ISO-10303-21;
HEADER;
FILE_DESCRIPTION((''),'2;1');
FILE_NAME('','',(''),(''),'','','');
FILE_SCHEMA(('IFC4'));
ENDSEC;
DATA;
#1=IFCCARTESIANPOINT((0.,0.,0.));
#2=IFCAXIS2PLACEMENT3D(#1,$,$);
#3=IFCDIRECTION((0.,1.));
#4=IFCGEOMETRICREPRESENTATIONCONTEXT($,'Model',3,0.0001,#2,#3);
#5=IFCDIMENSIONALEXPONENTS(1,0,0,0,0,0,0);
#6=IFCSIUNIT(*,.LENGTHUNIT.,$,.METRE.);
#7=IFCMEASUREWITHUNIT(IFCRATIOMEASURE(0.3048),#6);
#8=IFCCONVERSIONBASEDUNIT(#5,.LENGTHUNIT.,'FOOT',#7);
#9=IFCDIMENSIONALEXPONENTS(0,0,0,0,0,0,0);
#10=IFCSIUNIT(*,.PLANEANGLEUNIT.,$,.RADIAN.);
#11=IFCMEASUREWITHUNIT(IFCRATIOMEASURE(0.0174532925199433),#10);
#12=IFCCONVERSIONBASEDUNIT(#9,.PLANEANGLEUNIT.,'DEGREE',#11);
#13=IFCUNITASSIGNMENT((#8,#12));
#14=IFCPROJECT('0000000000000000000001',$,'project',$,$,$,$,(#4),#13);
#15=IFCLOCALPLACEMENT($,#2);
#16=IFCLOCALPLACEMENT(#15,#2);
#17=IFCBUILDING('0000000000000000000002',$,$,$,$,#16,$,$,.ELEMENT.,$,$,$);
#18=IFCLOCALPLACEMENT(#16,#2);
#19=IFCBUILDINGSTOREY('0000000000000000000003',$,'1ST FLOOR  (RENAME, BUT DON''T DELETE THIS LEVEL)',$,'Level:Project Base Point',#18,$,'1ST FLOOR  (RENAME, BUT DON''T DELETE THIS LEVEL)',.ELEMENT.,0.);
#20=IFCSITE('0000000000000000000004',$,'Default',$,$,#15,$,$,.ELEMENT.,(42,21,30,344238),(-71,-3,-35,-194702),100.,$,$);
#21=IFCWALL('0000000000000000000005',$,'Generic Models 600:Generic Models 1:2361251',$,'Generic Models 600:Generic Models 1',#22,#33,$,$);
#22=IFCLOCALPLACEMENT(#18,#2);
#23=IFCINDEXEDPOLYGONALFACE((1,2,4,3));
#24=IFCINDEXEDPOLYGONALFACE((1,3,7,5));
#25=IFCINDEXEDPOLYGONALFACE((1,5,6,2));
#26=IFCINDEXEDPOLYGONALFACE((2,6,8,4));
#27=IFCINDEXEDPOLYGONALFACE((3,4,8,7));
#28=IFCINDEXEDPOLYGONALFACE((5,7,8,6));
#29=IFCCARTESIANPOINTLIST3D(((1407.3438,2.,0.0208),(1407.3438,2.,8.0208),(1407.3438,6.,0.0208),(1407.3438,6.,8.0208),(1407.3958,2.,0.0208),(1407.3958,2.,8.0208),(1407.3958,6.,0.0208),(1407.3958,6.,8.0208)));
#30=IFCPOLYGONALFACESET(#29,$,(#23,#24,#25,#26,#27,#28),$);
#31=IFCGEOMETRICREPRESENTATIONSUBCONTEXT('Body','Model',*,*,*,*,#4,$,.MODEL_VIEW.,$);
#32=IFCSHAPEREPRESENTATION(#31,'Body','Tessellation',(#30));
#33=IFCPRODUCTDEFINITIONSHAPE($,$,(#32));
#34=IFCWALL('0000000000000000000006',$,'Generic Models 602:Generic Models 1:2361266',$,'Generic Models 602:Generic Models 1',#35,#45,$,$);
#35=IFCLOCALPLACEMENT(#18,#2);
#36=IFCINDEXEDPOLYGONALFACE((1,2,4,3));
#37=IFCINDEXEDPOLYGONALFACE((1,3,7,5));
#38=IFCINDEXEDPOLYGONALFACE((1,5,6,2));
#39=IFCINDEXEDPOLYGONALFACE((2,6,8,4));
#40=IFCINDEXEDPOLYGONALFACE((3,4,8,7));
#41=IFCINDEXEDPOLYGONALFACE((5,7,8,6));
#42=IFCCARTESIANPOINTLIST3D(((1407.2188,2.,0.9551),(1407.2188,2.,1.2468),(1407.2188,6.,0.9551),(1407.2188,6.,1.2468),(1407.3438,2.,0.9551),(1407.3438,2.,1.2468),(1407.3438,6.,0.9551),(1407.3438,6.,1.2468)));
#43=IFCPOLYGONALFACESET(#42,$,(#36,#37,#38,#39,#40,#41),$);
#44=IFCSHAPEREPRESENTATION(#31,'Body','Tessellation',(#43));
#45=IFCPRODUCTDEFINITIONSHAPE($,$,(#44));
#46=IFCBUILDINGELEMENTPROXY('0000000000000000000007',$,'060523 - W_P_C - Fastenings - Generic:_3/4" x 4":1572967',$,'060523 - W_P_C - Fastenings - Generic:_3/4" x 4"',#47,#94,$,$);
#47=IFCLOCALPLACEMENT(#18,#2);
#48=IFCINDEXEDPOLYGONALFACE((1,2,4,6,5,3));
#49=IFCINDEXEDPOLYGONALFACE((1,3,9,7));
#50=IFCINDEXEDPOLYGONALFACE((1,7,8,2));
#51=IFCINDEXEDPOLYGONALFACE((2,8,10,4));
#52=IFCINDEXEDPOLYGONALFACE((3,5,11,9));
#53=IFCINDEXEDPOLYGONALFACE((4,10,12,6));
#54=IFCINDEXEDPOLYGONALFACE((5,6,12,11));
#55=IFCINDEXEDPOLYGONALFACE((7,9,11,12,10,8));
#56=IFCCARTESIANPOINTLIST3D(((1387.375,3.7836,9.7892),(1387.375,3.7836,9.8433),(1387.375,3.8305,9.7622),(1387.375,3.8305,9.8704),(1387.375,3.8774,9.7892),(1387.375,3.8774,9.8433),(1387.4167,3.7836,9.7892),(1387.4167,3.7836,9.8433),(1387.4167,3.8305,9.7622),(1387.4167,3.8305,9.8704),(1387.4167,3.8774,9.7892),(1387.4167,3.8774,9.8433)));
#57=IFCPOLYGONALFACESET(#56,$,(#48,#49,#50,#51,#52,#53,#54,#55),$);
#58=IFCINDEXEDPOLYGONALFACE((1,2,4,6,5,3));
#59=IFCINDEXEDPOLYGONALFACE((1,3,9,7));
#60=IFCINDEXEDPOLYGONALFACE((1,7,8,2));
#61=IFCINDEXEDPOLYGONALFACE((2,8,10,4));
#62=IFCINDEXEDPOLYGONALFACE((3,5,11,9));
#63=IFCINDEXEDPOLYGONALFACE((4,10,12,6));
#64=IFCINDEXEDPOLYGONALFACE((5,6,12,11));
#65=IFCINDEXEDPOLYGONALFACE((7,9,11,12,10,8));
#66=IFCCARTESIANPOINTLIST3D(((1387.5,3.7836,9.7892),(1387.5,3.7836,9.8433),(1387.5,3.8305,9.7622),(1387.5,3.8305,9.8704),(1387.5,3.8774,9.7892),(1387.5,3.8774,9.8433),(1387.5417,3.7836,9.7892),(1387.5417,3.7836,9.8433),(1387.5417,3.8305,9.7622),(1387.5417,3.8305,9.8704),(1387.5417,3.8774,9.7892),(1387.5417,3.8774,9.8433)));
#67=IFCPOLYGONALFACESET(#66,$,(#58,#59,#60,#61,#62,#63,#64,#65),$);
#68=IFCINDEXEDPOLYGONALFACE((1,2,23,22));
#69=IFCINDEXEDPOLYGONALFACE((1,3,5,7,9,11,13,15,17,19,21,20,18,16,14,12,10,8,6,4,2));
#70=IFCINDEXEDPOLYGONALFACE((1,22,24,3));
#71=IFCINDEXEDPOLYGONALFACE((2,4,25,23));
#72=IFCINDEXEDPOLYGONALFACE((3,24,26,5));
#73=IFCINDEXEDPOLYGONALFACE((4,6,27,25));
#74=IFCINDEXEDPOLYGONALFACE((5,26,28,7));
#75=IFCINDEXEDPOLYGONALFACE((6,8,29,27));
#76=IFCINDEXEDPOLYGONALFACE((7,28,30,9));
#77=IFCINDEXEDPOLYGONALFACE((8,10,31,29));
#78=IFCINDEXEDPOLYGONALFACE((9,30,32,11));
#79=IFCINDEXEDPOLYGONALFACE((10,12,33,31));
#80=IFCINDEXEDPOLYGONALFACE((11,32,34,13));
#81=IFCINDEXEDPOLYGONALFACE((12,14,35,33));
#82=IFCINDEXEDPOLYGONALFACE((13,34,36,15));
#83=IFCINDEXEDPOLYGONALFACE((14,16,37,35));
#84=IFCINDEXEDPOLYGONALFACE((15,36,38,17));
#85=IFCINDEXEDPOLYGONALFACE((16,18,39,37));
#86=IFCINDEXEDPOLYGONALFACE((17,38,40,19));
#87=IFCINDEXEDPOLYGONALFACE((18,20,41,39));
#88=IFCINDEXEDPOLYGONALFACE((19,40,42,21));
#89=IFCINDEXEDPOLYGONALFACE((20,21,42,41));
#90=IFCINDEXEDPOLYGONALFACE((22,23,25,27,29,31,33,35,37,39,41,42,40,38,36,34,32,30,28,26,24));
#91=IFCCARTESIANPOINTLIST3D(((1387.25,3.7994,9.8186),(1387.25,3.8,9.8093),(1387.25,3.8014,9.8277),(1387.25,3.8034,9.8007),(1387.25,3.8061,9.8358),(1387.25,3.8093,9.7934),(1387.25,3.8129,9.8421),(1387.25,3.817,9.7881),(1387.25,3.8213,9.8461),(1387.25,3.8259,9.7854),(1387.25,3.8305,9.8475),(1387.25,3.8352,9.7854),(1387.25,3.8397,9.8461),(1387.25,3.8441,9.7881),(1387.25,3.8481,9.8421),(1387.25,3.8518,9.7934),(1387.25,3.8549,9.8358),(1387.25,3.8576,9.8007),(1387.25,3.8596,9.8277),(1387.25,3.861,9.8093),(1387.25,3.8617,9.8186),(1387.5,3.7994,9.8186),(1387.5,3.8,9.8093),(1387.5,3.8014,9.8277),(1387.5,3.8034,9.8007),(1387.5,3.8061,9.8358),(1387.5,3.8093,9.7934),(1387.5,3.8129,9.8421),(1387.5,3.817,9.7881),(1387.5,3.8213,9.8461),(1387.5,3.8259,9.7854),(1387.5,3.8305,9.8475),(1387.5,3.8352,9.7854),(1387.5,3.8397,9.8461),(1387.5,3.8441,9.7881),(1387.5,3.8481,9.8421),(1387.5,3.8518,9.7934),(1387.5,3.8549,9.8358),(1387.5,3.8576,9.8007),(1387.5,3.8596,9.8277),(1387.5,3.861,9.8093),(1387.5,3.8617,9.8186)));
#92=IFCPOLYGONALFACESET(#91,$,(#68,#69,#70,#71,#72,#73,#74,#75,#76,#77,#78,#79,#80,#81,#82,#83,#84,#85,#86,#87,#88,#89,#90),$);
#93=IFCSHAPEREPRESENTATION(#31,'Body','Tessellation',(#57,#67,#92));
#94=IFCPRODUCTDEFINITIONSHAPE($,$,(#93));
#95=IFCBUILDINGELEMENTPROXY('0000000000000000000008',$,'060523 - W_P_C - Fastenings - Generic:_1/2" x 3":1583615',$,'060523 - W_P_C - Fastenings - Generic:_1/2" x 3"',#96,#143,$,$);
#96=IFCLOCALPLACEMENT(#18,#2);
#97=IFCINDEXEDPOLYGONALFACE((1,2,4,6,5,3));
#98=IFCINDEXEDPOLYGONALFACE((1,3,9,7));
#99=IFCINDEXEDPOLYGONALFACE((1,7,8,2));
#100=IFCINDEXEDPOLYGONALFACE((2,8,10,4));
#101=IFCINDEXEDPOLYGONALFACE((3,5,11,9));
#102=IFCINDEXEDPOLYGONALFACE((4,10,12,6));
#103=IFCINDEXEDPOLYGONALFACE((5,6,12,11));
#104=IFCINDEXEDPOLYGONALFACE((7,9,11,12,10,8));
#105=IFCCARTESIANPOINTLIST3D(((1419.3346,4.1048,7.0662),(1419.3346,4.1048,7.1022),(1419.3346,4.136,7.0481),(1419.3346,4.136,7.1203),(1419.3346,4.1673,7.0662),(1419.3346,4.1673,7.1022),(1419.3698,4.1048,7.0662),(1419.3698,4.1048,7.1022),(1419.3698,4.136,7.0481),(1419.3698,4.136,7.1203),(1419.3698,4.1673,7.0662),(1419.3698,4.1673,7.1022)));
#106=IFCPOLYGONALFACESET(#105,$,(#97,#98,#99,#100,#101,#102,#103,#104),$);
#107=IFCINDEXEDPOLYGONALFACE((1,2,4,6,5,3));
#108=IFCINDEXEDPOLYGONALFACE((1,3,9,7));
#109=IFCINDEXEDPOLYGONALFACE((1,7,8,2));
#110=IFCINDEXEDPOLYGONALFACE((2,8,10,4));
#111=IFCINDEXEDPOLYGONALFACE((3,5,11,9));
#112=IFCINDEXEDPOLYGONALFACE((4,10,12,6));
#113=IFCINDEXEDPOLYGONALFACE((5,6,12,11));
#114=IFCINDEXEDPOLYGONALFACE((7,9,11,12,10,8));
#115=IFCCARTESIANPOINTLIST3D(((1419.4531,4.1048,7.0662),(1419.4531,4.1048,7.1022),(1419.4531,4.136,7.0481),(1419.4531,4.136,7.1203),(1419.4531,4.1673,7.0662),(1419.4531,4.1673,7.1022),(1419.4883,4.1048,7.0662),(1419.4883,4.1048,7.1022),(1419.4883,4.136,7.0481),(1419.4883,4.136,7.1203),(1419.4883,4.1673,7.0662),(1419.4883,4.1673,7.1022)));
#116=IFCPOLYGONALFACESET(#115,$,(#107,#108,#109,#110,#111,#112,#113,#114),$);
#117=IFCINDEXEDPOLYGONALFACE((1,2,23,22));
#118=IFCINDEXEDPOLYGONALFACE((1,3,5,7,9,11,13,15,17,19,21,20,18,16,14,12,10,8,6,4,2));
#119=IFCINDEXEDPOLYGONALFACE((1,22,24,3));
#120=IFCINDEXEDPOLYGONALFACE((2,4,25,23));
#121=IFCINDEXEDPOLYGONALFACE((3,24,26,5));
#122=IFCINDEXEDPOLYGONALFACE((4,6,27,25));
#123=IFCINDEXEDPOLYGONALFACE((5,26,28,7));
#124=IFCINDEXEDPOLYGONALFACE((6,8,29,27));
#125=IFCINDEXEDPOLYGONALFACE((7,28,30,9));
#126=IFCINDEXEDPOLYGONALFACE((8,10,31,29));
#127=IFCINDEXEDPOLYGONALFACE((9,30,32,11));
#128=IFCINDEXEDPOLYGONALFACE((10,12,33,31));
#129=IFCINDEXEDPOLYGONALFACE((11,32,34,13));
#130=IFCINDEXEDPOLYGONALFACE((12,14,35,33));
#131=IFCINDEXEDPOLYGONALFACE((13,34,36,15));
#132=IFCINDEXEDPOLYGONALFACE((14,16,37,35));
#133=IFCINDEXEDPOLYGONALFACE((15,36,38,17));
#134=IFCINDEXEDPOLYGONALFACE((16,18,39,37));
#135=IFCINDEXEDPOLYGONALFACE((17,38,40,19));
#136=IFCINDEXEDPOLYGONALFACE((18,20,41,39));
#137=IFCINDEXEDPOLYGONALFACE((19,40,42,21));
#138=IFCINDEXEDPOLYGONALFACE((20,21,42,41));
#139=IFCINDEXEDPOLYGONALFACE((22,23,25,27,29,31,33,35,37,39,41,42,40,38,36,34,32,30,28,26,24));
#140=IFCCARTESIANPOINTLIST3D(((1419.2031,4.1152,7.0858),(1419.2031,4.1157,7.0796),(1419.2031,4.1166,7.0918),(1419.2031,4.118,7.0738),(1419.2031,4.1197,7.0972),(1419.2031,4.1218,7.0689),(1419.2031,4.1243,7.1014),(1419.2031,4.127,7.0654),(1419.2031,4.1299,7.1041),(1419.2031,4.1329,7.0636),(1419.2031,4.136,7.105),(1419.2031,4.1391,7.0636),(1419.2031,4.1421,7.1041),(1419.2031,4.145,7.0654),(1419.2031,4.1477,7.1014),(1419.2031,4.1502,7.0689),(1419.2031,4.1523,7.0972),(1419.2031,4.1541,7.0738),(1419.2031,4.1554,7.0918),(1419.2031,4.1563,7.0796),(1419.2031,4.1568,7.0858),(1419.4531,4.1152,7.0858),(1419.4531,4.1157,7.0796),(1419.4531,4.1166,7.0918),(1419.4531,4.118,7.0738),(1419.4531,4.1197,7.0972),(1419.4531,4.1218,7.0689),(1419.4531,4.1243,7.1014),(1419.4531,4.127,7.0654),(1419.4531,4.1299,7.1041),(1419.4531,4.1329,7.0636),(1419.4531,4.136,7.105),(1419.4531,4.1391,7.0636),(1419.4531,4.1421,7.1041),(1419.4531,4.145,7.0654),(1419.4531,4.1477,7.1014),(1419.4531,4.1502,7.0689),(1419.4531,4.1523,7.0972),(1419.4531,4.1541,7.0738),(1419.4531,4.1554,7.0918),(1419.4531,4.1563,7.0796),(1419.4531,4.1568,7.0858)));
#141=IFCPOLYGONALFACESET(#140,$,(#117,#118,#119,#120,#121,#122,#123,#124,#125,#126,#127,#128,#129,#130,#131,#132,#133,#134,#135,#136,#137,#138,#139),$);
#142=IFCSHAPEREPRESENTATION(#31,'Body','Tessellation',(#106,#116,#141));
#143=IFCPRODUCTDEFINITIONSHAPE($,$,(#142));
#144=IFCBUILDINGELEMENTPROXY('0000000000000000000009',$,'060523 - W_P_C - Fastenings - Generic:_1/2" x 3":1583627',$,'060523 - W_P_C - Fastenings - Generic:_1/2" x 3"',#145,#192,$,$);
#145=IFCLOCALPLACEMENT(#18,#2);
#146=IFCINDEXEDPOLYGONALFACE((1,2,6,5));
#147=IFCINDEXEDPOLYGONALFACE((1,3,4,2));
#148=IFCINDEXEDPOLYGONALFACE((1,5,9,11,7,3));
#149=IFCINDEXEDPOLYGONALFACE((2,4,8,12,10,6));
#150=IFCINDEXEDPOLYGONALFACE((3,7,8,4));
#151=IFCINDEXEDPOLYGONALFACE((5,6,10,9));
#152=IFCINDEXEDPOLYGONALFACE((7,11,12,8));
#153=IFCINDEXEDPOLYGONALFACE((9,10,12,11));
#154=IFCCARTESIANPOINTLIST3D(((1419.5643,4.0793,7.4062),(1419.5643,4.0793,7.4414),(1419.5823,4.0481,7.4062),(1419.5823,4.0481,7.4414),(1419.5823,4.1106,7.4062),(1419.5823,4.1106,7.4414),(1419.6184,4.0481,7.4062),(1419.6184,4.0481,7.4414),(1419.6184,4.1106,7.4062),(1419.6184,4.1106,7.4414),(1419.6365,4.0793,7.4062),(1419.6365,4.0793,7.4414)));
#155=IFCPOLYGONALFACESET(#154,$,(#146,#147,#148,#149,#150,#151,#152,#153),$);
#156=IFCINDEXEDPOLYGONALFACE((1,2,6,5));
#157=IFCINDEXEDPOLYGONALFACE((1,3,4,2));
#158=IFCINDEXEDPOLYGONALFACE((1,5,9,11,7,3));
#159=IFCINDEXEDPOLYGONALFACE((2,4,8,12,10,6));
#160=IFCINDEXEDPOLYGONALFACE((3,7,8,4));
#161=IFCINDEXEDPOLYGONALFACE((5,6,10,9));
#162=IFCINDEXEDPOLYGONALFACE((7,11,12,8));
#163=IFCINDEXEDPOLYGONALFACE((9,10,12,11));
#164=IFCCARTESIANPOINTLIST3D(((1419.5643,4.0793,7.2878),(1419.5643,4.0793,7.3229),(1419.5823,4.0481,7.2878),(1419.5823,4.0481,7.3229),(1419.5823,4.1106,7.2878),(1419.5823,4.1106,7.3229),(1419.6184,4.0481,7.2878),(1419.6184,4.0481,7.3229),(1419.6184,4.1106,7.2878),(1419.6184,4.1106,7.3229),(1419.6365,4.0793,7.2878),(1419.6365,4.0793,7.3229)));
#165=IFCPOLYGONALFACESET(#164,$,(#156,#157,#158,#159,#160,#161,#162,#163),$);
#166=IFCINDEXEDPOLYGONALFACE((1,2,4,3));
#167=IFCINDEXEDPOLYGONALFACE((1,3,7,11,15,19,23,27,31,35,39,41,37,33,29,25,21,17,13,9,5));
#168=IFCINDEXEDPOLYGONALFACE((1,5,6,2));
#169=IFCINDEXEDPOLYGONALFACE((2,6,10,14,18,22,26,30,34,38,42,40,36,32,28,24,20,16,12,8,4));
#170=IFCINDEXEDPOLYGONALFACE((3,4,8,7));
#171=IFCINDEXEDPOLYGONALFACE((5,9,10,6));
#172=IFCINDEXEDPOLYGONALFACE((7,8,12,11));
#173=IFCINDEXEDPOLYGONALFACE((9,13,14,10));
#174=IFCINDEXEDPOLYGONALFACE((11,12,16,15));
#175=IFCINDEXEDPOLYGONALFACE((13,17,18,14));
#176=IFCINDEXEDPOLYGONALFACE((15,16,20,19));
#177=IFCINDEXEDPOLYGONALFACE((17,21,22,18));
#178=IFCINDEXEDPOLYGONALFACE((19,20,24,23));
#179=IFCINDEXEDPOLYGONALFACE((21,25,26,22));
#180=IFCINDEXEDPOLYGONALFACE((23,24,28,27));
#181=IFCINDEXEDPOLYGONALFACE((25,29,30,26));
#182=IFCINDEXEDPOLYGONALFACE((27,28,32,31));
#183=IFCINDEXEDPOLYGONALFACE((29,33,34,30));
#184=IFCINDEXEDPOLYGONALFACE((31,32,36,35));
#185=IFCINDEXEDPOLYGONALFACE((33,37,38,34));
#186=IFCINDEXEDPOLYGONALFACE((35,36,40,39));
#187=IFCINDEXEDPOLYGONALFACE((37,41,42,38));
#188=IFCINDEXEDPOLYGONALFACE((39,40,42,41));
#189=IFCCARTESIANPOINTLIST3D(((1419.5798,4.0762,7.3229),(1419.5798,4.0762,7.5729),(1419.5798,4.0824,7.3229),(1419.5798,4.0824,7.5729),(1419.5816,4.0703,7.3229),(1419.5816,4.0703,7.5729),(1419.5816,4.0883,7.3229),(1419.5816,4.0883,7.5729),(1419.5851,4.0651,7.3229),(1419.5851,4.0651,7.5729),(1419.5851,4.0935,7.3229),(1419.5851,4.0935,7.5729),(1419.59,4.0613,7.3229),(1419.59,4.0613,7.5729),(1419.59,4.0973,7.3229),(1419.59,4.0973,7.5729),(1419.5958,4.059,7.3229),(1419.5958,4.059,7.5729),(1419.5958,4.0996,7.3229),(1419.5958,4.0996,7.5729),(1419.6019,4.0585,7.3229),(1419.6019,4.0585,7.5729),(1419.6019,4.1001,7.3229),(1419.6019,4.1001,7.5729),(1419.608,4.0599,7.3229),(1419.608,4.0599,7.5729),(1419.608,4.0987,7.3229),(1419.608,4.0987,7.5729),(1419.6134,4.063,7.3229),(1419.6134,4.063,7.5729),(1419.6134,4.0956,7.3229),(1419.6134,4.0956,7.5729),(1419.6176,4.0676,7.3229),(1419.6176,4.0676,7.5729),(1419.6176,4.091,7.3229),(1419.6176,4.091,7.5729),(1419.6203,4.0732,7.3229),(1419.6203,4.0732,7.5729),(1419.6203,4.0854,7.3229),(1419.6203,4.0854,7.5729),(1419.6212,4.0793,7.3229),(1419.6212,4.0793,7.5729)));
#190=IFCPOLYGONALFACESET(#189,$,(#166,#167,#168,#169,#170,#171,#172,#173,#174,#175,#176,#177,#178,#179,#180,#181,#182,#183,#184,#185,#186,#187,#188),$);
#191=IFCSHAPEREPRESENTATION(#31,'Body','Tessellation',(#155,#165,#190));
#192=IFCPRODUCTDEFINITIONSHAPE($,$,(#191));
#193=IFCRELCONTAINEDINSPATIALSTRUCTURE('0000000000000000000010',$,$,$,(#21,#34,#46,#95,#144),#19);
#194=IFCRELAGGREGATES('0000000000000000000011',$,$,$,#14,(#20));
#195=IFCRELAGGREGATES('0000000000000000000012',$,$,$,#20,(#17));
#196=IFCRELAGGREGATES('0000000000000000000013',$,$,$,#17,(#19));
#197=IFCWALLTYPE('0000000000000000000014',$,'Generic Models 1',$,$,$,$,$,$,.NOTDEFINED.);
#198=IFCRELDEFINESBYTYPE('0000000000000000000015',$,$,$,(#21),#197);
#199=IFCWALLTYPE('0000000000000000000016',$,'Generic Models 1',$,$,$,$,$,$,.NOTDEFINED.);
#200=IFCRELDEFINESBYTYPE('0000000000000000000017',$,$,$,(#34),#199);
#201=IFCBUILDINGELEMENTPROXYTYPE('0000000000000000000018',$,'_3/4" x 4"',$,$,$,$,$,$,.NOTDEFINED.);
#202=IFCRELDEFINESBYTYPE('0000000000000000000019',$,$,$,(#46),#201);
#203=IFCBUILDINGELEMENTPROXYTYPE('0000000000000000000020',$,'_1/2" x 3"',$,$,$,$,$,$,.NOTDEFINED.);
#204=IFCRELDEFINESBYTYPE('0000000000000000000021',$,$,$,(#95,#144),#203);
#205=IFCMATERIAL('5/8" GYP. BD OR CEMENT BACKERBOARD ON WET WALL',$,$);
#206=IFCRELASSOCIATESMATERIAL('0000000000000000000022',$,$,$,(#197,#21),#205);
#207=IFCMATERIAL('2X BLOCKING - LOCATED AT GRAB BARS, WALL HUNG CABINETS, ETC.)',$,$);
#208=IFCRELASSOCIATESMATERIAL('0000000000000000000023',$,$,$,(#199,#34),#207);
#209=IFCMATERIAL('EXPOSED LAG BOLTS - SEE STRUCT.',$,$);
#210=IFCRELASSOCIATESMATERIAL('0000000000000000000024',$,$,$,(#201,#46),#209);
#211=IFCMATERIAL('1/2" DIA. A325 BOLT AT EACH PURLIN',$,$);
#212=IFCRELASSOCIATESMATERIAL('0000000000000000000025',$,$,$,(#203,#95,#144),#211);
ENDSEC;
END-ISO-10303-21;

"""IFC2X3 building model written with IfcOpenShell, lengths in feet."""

from ifc_helpers import new_model, entity, si_unit, converted_unit, direction, frame, frame_2d, origin, place, context, subcontext, project, spatial, polyline, rectangle, circle, outline, extrude, source, transform, mapped, material, type_object, type_shapes, element, save


model = new_model("IFC2X3")

# Units and contexts
model_context = context("Model", 3, precision=0.0001, world=origin(), true_north=direction((0.0, 1.0)))
body_context = subcontext(model_context, "Body", "Model", "MODEL_VIEW")
ifc_project = project(units=[converted_unit("LENGTHUNIT", "FOOT", entity("IfcRatioMeasure", 0.3048), si_unit("LENGTHUNIT", "METRE"), dimensions=[1, 0, 0, 0, 0, 0, 0]), converted_unit("PLANEANGLEUNIT", "DEGREE", entity("IfcRatioMeasure", 0.0174532925199433), si_unit("PLANEANGLEUNIT", "RADIAN"), dimensions=[0, 0, 0, 0, 0, 0, 0])], contexts=[model_context])

# Site, building, storey
site_placement = place(None, origin())
site = spatial("IfcSite", under=ifc_project, at=site_placement, Name="Default", CompositionType="ELEMENT", RefLatitude=(42, 21, 30, 344238), RefLongitude=(-71, -3, -35, -194702), RefElevation=100.0)
building_placement = place(site_placement, origin())
building = spatial("IfcBuilding", under=site, at=building_placement, CompositionType="ELEMENT")
storey_placement = place(building_placement, origin())
storey = spatial("IfcBuildingStorey", under=building, at=storey_placement, Name="1ST FLOOR  (RENAME, BUT DON'T DELETE THIS LEVEL)", ObjectType="Level:Project Base Point", LongName="1ST FLOOR  (RENAME, BUT DON'T DELETE THIS LEVEL)", CompositionType="ELEMENT", Elevation=0.0)

# Walls
ifc_material_1 = material(Name="5/8\" GYP. BD OR CEMENT BACKERBOARD ON WET WALL")
ifc_material_2 = material(Name="2X BLOCKING - LOCATED AT GRAB BARS, WALL HUNG CABINETS, ETC.)")
wall_type_1 = type_object("IfcWallType", Name="Generic Models 1", PredefinedType="NOTDEFINED", material=ifc_material_1)
wall_1_placement = place(storey_placement, frame((1407.3438, 2.0, 0.0208), z_axis=(0.0, 0.0, 1.0), x_axis=(0.0, 1.0, 0.0)))
element("IfcWall", 1, at=wall_1_placement, inside=storey, type_object=wall_type_1, material=ifc_material_1, Name="Generic Models 600:Generic Models 1:2361251", ObjectType="Generic Models 600:Generic Models 1", context=body_context, shape_type="SweptSolid", body=[
    extrude(rectangle(XDim=4.0, YDim=0.0521, at=frame_2d((0.0, 0.0), x_axis=(1.0, 0.0))), frame((2.0, -0.026, 0.0)), (0.0, 0.0, 1.0), 8.0),
])
wall_type_2 = type_object("IfcWallType", Name="Generic Models 1", PredefinedType="NOTDEFINED", material=ifc_material_2)
wall_2_placement = place(storey_placement, frame((1407.2188, 2.0, 0.9551), z_axis=(0.0, 0.0, 1.0), x_axis=(0.0, 1.0, 0.0)))
element("IfcWall", 2, at=wall_2_placement, inside=storey, type_object=wall_type_2, material=ifc_material_2, Name="Generic Models 602:Generic Models 1:2361266", ObjectType="Generic Models 602:Generic Models 1", context=body_context, shape_type="SweptSolid", body=[
    extrude(rectangle(XDim=4.0, YDim=0.125, at=frame_2d((0.0, 0.0), x_axis=(1.0, 0.0))), frame((2.0, -0.0625, 0.0)), (0.0, 0.0, 1.0), 0.2917),
])

# Building element proxies
ifc_material_3 = material(Name="EXPOSED LAG BOLTS - SEE STRUCT.")
building_element_proxy_type_1 = type_object("IfcBuildingElementProxyType", Name="_3/4\" x 4\"", PredefinedType="NOTDEFINED", material=ifc_material_3)
shared_shape_1 = source(origin(), body_context, "Body", "SweptSolid", [
    extrude(outline(polyline([(-0.0271, -0.0469), (0.0271, -0.0469), (0.0541, 0.0), (0.0271, 0.0469), (-0.0271, 0.0469), (-0.0541, 0.0), (-0.0271, -0.0469)])), frame((0.0, 0.0, -0.125), z_axis=(0.0, 0.0, 1.0), x_axis=(0.866025, -0.5, 0.0)), (0.0, 0.0, 1.0), 0.0417),
    extrude(outline(polyline([(-0.0271, -0.0469), (0.0271, -0.0469), (0.0541, 0.0), (0.0271, 0.0469), (-0.0271, 0.0469), (-0.0541, 0.0), (-0.0271, -0.0469)])), frame((0.0, 0.0, 0.0), z_axis=(0.0, 0.0, 1.0), x_axis=(0.0, -1.0, 0.0)), (0.0, 0.0, 1.0), 0.0417),
    extrude(circle(Radius=0.0312, at=frame_2d((0.0, 0.0), x_axis=(1.0, 0.0))), frame((0.0, 0.0, -0.25), z_axis=(0.0, 0.0, 1.0), x_axis=(0.0, 1.0, 0.0)), (0.0, 0.0, 1.0), 0.25),
])
type_shapes(building_element_proxy_type_1, [shared_shape_1])
proxy_placement = place(storey_placement, frame((1387.5, 3.8305, 9.8163), z_axis=(1.0, 0.0, 0.0), x_axis=(0.0, 1.0, 0.0)))
element("IfcBuildingElementProxy", 3, at=proxy_placement, inside=storey, type_object=building_element_proxy_type_1, material=ifc_material_3, Name="060523 - W_P_C - Fastenings - Generic:_3/4\" x 4\":1572967", ObjectType="060523 - W_P_C - Fastenings - Generic:_3/4\" x 4\"", context=body_context, shape_type="MappedRepresentation", body=[
    mapped(shared_shape_1, transform((0.0, 0.0, 0.0), scale=1.0)),
])
ifc_material_4 = material(Name="1/2\" DIA. A325 BOLT AT EACH PURLIN")
building_element_proxy_type_2 = type_object("IfcBuildingElementProxyType", Name="_1/2\" x 3\"", PredefinedType="NOTDEFINED", material=ifc_material_4)
shared_shape_2 = source(origin(), body_context, "Body", "SweptSolid", [
    extrude(outline(polyline([(-0.018, -0.0313), (0.018, -0.0313), (0.0361, 0.0), (0.018, 0.0312), (-0.018, 0.0312), (-0.0361, 0.0), (-0.018, -0.0313)])), frame((0.0, 0.0, -0.1185), z_axis=(0.0, 0.0, 1.0), x_axis=(0.866025, -0.5, 0.0)), (0.0, 0.0, 1.0), 0.0352),
    extrude(outline(polyline([(-0.018, -0.0313), (0.018, -0.0313), (0.0361, 0.0), (0.018, 0.0313), (-0.018, 0.0313), (-0.0361, 0.0), (-0.018, -0.0313)])), frame((0.0, 0.0, 0.0), z_axis=(0.0, 0.0, 1.0), x_axis=(0.0, -1.0, 0.0)), (0.0, 0.0, 1.0), 0.0352),
    extrude(circle(Radius=0.0208, at=frame_2d((0.0, 0.0), x_axis=(1.0, 0.0))), frame((0.0, 0.0, -0.25), z_axis=(0.0, 0.0, 1.0), x_axis=(0.0, 1.0, 0.0)), (0.0, 0.0, 1.0), 0.25),
])
type_shapes(building_element_proxy_type_2, [shared_shape_2])
for number, where, z_axis, x_axis, name in (
    (4, (1419.4531, 4.136, 7.0842), (1.0, 0.0, 0.0), (0.0, 1.0, 0.0), "060523 - W_P_C - Fastenings - Generic:_1/2\" x 3\":1583615"),
    (5, (1419.6004, 4.0793, 7.3229), (0.0, 0.0, -1.0), (0.0, 1.0, 0.0), "060523 - W_P_C - Fastenings - Generic:_1/2\" x 3\":1583627"),
):
    element("IfcBuildingElementProxy", number, at=place(storey_placement, frame(where, z_axis=z_axis, x_axis=x_axis)), inside=storey, type_object=building_element_proxy_type_2, material=ifc_material_4, Name=name, ObjectType="060523 - W_P_C - Fastenings - Generic:_1/2\" x 3\"", context=body_context, shape_type="MappedRepresentation", body=[
        mapped(shared_shape_2, transform((0.0, 0.0, 0.0), scale=1.0)),
    ])

save(model, "model.ifc")
